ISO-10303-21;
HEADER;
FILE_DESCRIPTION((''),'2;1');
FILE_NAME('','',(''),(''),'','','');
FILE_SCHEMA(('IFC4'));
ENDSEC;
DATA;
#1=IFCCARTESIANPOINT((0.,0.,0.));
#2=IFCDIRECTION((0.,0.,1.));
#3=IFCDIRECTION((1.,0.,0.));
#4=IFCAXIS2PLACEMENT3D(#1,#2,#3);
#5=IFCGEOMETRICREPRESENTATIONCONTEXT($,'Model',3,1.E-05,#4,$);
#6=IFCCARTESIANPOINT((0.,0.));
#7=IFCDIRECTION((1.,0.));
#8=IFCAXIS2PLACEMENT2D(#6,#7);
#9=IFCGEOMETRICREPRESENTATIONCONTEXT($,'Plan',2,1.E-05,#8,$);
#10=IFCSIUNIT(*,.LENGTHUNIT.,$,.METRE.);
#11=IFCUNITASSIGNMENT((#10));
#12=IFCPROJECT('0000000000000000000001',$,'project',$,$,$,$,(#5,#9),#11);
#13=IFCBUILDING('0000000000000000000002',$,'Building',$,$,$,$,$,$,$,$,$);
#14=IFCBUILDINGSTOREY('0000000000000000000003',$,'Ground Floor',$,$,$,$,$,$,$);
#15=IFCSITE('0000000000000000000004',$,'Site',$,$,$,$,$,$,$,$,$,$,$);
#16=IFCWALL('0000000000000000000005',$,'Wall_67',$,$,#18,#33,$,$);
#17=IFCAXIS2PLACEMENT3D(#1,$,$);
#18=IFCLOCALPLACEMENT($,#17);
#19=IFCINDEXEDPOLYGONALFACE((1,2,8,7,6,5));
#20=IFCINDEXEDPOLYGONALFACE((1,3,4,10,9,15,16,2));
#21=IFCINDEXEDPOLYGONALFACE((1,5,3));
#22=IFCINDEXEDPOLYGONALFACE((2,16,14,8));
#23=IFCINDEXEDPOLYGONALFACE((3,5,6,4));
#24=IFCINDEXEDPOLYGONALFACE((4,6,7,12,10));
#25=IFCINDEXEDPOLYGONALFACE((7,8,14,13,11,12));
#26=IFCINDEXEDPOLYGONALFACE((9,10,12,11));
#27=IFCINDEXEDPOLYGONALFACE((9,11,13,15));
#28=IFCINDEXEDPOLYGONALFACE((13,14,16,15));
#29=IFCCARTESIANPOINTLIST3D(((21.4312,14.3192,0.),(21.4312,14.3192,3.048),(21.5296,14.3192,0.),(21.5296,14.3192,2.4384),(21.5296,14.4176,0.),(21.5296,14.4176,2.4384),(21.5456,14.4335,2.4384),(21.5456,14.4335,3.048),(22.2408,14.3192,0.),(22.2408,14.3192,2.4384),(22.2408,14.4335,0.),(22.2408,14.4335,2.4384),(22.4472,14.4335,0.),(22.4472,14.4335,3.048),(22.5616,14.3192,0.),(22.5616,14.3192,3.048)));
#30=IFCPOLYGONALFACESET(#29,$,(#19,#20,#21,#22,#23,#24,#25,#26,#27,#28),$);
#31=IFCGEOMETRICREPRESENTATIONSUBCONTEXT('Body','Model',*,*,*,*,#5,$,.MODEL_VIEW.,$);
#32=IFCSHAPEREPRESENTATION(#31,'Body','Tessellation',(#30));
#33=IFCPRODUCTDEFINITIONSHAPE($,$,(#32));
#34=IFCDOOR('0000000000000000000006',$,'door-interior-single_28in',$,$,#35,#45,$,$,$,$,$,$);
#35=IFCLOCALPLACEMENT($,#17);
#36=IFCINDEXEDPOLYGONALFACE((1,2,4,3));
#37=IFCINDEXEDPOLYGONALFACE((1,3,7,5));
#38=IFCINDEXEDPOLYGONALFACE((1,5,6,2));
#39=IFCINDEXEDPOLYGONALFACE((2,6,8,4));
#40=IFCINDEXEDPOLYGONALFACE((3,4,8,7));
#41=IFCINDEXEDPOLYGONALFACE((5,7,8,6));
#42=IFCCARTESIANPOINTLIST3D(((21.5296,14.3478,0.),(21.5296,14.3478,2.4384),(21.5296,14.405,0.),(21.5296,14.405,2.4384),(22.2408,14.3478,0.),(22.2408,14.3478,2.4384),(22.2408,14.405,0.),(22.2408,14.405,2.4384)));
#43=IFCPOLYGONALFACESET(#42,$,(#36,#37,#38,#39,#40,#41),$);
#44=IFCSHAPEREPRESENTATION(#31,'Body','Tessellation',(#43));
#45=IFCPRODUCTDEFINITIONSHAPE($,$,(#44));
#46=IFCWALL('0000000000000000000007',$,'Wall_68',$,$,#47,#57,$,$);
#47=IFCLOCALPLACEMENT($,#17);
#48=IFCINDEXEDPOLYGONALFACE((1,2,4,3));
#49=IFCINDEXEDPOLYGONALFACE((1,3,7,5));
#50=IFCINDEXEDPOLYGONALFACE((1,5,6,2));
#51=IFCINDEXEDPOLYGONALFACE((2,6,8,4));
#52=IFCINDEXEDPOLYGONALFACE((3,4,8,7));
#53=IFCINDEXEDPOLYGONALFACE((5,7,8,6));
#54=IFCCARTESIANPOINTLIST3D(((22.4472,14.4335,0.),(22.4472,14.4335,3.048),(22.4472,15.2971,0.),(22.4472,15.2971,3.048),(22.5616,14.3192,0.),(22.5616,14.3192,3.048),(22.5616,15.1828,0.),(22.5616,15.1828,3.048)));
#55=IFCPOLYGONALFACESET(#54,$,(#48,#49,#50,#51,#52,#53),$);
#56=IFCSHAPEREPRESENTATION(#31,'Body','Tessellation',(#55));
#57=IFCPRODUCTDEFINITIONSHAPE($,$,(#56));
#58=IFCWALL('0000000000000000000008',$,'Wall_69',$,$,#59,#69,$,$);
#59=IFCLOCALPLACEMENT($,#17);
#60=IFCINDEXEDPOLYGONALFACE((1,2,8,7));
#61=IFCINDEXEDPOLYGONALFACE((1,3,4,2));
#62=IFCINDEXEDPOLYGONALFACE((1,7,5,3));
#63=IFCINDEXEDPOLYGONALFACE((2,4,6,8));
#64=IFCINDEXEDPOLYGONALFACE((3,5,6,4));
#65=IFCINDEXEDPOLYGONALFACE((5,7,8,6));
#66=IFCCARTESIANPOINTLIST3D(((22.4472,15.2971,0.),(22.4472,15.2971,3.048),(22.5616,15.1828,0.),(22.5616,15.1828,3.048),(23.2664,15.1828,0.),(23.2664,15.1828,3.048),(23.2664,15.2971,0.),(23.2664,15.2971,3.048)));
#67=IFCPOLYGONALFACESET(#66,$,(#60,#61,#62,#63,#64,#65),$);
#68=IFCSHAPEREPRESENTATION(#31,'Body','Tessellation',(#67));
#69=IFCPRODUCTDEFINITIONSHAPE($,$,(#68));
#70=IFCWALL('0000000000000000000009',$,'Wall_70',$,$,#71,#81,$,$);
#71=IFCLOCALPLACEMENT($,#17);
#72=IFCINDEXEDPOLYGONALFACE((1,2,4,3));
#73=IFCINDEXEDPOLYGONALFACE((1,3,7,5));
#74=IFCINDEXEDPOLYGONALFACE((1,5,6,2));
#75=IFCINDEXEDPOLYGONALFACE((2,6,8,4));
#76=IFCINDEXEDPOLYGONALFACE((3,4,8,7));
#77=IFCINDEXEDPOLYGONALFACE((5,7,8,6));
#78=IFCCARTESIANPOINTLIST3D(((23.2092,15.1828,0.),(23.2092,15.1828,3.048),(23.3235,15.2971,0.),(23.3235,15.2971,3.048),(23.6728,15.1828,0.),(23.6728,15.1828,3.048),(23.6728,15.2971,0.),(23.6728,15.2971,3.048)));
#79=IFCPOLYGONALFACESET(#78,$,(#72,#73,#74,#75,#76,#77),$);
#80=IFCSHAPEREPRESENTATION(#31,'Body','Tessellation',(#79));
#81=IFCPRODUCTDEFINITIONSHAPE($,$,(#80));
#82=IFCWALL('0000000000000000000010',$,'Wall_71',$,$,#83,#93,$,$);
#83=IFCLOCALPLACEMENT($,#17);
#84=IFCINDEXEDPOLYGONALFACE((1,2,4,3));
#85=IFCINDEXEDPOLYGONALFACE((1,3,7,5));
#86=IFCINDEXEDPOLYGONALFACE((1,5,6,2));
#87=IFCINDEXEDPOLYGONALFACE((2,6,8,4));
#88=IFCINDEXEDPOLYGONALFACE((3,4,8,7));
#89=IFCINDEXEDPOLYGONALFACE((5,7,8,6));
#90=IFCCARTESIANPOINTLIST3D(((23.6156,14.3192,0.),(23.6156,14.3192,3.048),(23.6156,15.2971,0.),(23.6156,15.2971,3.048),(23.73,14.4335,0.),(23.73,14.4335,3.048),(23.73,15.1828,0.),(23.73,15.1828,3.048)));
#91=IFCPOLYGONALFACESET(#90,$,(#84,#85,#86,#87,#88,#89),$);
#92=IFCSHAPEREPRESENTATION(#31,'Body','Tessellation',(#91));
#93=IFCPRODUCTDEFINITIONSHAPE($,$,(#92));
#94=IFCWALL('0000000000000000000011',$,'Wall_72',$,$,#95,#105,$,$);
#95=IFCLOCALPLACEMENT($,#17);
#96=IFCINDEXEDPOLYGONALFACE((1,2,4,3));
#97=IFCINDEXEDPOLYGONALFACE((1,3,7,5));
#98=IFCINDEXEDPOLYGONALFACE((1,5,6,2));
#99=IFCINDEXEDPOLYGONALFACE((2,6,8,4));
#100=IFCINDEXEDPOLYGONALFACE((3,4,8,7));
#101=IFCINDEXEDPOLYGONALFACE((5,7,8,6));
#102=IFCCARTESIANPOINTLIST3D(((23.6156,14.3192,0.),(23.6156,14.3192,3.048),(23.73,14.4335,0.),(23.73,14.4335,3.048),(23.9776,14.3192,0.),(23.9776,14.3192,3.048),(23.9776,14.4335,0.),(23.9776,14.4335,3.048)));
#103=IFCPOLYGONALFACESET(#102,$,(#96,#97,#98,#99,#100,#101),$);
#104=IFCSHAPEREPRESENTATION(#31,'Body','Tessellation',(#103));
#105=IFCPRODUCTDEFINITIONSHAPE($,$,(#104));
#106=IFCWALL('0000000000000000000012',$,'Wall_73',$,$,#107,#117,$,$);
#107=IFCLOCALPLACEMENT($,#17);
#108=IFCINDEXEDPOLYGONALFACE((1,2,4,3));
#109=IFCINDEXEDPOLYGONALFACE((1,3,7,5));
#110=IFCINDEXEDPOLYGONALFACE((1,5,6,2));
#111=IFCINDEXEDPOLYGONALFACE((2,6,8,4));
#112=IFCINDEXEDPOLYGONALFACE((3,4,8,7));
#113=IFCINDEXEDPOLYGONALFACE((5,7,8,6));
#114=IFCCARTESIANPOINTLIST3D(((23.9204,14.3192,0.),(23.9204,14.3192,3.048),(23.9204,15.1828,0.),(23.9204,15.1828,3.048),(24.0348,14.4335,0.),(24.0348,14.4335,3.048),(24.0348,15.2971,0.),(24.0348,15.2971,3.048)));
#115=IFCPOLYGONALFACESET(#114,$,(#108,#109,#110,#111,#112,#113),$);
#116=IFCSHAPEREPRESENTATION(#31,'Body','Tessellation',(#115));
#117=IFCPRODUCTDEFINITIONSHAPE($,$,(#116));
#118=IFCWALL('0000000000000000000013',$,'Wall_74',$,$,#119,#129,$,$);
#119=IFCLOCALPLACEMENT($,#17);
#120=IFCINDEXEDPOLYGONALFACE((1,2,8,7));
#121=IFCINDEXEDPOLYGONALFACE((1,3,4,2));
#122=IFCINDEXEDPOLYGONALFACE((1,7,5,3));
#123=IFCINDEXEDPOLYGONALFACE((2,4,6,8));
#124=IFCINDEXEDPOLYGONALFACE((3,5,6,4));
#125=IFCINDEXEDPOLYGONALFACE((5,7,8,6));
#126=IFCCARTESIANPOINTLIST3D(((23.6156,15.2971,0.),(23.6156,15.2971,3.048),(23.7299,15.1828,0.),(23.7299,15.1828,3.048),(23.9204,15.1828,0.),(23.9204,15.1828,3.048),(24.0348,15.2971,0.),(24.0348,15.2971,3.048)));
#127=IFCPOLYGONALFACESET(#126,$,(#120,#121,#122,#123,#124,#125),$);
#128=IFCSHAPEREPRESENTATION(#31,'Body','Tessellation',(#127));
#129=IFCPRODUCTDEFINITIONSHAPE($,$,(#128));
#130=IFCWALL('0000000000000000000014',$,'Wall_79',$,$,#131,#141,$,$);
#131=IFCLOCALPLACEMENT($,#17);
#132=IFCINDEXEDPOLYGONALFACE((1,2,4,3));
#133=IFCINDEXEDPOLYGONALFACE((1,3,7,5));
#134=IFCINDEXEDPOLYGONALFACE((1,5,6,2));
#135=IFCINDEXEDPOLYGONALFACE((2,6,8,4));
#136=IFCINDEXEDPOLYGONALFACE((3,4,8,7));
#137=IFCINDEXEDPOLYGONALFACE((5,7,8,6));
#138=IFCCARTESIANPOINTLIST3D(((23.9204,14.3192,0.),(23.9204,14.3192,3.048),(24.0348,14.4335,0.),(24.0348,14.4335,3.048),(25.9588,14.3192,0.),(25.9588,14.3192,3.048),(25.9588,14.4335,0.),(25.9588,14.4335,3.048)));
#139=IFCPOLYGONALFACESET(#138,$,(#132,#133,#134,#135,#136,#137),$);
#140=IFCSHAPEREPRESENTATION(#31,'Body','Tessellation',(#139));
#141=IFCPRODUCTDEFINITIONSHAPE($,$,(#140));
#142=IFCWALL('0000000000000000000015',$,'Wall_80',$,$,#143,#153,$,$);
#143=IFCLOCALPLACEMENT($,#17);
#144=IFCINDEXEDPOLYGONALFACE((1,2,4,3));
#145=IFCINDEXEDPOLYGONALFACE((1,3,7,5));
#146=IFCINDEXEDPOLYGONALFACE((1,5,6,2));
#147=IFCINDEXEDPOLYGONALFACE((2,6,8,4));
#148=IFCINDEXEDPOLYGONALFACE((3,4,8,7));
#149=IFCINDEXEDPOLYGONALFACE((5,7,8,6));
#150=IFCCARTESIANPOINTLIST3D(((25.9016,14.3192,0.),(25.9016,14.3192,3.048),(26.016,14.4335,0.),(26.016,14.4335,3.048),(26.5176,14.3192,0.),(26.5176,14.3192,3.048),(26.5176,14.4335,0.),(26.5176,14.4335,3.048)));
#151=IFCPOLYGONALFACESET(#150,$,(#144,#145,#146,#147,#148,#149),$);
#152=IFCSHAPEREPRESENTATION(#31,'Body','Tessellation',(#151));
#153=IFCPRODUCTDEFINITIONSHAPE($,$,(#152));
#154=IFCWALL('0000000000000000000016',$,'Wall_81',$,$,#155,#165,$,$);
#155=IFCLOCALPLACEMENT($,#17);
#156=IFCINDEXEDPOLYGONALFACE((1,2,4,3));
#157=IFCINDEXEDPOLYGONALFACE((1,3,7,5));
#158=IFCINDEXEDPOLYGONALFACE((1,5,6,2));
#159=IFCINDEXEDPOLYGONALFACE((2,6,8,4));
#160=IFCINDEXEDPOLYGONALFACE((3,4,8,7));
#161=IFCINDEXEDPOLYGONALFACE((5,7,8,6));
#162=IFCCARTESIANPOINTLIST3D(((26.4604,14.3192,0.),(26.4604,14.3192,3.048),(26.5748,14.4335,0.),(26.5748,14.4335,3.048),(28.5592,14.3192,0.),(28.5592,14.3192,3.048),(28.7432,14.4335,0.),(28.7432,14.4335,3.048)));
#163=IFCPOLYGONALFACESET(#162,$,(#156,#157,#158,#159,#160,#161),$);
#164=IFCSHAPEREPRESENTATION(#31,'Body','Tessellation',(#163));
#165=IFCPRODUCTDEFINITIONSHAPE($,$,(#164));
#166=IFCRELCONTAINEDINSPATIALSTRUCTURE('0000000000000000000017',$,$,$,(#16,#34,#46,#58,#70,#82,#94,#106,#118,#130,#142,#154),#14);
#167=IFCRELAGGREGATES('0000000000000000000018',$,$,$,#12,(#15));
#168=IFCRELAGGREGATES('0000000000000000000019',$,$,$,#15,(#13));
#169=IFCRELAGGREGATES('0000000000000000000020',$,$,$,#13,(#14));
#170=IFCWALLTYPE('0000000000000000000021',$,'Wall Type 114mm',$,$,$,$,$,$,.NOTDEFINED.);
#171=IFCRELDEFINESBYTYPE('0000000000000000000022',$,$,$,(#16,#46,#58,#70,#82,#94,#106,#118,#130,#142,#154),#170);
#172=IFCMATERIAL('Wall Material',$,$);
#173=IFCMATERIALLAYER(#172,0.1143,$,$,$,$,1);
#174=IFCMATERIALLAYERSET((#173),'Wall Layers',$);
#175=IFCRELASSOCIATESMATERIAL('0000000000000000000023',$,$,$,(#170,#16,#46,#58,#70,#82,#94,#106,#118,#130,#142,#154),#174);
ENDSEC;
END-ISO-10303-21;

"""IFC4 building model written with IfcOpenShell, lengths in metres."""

from ifc_helpers import new_model, si_unit, frame, origin_with_axes, origin_2d_with_axis, place, context, subcontext, project, spatial, line, indexed_curve, rectangle, outline, extrude, material, layer, layer_set, layer_usage, type_object, element, fill, save


model = new_model("IFC4")

# Units and contexts
model_context = context("Model", 3, precision=1e-05, world=origin_with_axes())
plan_context = context("Plan", 2, precision=1e-05, world=origin_2d_with_axis())
body_context = subcontext(model_context, "Body", "Model", "MODEL_VIEW")
ifc_project = project(units=[si_unit("LENGTHUNIT", "METRE")], contexts=[model_context, plan_context])

# Site, building, storey
site = spatial("IfcSite", under=ifc_project, Name="Site")
building = spatial("IfcBuilding", under=site, Name="Building")
storey = spatial("IfcBuildingStorey", under=building, Name="Ground Floor")

# Shared definitions
ifc_material_1 = material(Name="Wall Material")
ifc_layer_1 = layer(ifc_material_1, 0.1143, Priority=1)
ifc_layer_set_1 = layer_set([ifc_layer_1], Name="Wall Layers")
wall_type_1 = type_object("IfcWallType", Name="Wall Type 114mm", PredefinedType="NOTDEFINED", material=ifc_layer_set_1)

# Wall, opening, door
ifc_layer_usage_1 = layer_usage(ifc_layer_set_1, "AXIS2", "POSITIVE", -0.0571)
wall_1_placement = place(None, frame((21.4884, 14.3764, 0.0), z_axis=(0.0, 0.0, 1.0), x_axis=(1.0, 0.0, 0.0)))
wall_1 = element("IfcWall", 1, at=wall_1_placement, inside=storey, type_object=wall_type_1, material=ifc_layer_usage_1, Name="Wall_67", context=body_context, shape_type="SweptSolid", body=[
    extrude(outline(indexed_curve([(-0.0571, -0.0571), (0.0571, 0.0571), (0.9589, 0.0571), (1.0732, -0.0571)], segments=[line(1, 2, 3, 4, 1)])), origin_with_axes(), (0.0, 0.0, 1.0), 3.048),
])
opening_1_placement = place(wall_1_placement, frame((0.3968, 0.0, 0.0), z_axis=(0.0, 0.0, 1.0), x_axis=(1.0, 0.0, 0.0)))
opening_1 = element("IfcOpeningElement", 2, at=opening_1_placement, cuts=wall_1, context=body_context, shape_type="SweptSolid", body=[
    extrude(rectangle(XDim=0.7112, YDim=0.5), None, (0.0, 0.0, 1.0), 2.4384),
])
door_1_placement = place(None, frame((21.8852, 14.3764, 0.0), z_axis=(0.0, 0.0, 1.0), x_axis=(-1.0, 0.0, 0.0)))
door_1 = element("IfcDoor", 3, at=door_1_placement, inside=storey, Name="door-interior-single_28in", context=body_context, shape_type="SweptSolid", body=[
    extrude(rectangle(XDim=0.7112, YDim=0.0571), None, (0.0, 0.0, 1.0), 2.4384),
])
fill(opening_1, door_1)

# Walls
ifc_layer_usage_2 = layer_usage(ifc_layer_set_1, "AXIS2", "POSITIVE", -0.0571)
wall_2_placement = place(None, frame((22.5044, 14.3764, 0.0), z_axis=(0.0, 0.0, 1.0), x_axis=(0.0, 1.0, 0.0)))
element("IfcWall", 4, at=wall_2_placement, inside=storey, type_object=wall_type_1, material=ifc_layer_usage_2, Name="Wall_68", context=body_context, shape_type="SweptSolid", body=[
    extrude(outline(indexed_curve([(-0.0571, -0.0571), (0.0571, 0.0571), (0.9207, 0.0571), (0.8064, -0.0571)], segments=[line(1, 2, 3, 4, 1)])), origin_with_axes(), (0.0, 0.0, 1.0), 3.048),
])
ifc_layer_usage_3 = layer_usage(ifc_layer_set_1, "AXIS2", "POSITIVE", -0.0571)
wall_3_placement = place(None, frame((22.5044, 15.24, 0.0), z_axis=(0.0, 0.0, 1.0), x_axis=(1.0, 0.0, 0.0)))
element("IfcWall", 5, at=wall_3_placement, inside=storey, type_object=wall_type_1, material=ifc_layer_usage_3, Name="Wall_69", context=body_context, shape_type="SweptSolid", body=[
    extrude(outline(indexed_curve([(0.0571, -0.0571), (-0.0571, 0.0571), (0.762, 0.0571), (0.762, -0.0571)], segments=[line(1, 2, 3, 4, 1)])), origin_with_axes(), (0.0, 0.0, 1.0), 3.048),
])
ifc_layer_usage_4 = layer_usage(ifc_layer_set_1, "AXIS2", "POSITIVE", -0.0571)
wall_4_placement = place(None, frame((23.2664, 15.24, 0.0), z_axis=(0.0, 0.0, 1.0), x_axis=(1.0, 0.0, 0.0)))
element("IfcWall", 6, at=wall_4_placement, inside=storey, type_object=wall_type_1, material=ifc_layer_usage_4, Name="Wall_70", context=body_context, shape_type="SweptSolid", body=[
    extrude(outline(indexed_curve([(-0.0571, -0.0571), (0.0571, 0.0571), (0.4064, 0.0571), (0.4064, -0.0571)], segments=[line(1, 2, 3, 4, 1)])), origin_with_axes(), (0.0, 0.0, 1.0), 3.048),
])
ifc_layer_usage_5 = layer_usage(ifc_layer_set_1, "AXIS2", "POSITIVE", -0.0571)
wall_5_placement = place(None, frame((23.6728, 15.24, 0.0), z_axis=(0.0, 0.0, 1.0), x_axis=(0.0, -1.0, 0.0)))
element("IfcWall", 7, at=wall_5_placement, inside=storey, type_object=wall_type_1, material=ifc_layer_usage_5, Name="Wall_71", context=body_context, shape_type="SweptSolid", body=[
    extrude(outline(indexed_curve([(-0.0572, -0.0571), (0.0572, 0.0571), (0.8064, 0.0571), (0.9207, -0.0571)], segments=[line(1, 2, 3, 4, 1)])), origin_with_axes(), (0.0, 0.0, 1.0), 3.048),
])
ifc_layer_usage_6 = layer_usage(ifc_layer_set_1, "AXIS2", "POSITIVE", -0.0571)
wall_6_placement = place(None, frame((23.6728, 14.3764, 0.0), z_axis=(0.0, 0.0, 1.0), x_axis=(1.0, 0.0, 0.0)))
element("IfcWall", 8, at=wall_6_placement, inside=storey, type_object=wall_type_1, material=ifc_layer_usage_6, Name="Wall_72", context=body_context, shape_type="SweptSolid", body=[
    extrude(outline(indexed_curve([(-0.0571, -0.0571), (0.0571, 0.0571), (0.3048, 0.0571), (0.3048, -0.0571)], segments=[line(1, 2, 3, 4, 1)])), origin_with_axes(), (0.0, 0.0, 1.0), 3.048),
])
ifc_layer_usage_7 = layer_usage(ifc_layer_set_1, "AXIS2", "POSITIVE", -0.0571)
wall_7_placement = place(None, frame((23.9776, 14.3764, 0.0), z_axis=(0.0, 0.0, 1.0), x_axis=(0.0, 1.0, 0.0)))
element("IfcWall", 9, at=wall_7_placement, inside=storey, type_object=wall_type_1, material=ifc_layer_usage_7, Name="Wall_73", context=body_context, shape_type="SweptSolid", body=[
    extrude(outline(indexed_curve([(0.0571, -0.0571), (-0.0571, 0.0571), (0.8064, 0.0571), (0.9207, -0.0571)], segments=[line(1, 2, 3, 4, 1)])), origin_with_axes(), (0.0, 0.0, 1.0), 3.048),
])
ifc_layer_usage_8 = layer_usage(ifc_layer_set_1, "AXIS2", "POSITIVE", -0.0571)
wall_8_placement = place(None, frame((23.9776, 15.24, 0.0), z_axis=(0.0, 0.0, 1.0), x_axis=(-1.0, 0.0, 0.0)))
element("IfcWall", 10, at=wall_8_placement, inside=storey, type_object=wall_type_1, material=ifc_layer_usage_8, Name="Wall_74", context=body_context, shape_type="SweptSolid", body=[
    extrude(outline(indexed_curve([(-0.0571, -0.0571), (0.0571, 0.0571), (0.2477, 0.0571), (0.362, -0.0571)], segments=[line(1, 2, 3, 4, 1)])), origin_with_axes(), (0.0, 0.0, 1.0), 3.048),
])
ifc_layer_usage_9 = layer_usage(ifc_layer_set_1, "AXIS2", "POSITIVE", -0.0571)
wall_9_placement = place(None, frame((23.9776, 14.3764, 0.0), z_axis=(0.0, 0.0, 1.0), x_axis=(1.0, 0.0, 0.0)))
element("IfcWall", 11, at=wall_9_placement, inside=storey, type_object=wall_type_1, material=ifc_layer_usage_9, Name="Wall_79", context=body_context, shape_type="SweptSolid", body=[
    extrude(outline(indexed_curve([(-0.0572, -0.0571), (0.0572, 0.0571), (1.9812, 0.0571), (1.9812, -0.0571)], segments=[line(1, 2, 3, 4, 1)])), origin_with_axes(), (0.0, 0.0, 1.0), 3.048),
])
ifc_layer_usage_10 = layer_usage(ifc_layer_set_1, "AXIS2", "POSITIVE", -0.0571)
wall_10_placement = place(None, frame((25.9588, 14.3764, 0.0), z_axis=(0.0, 0.0, 1.0), x_axis=(1.0, 0.0, 0.0)))
element("IfcWall", 12, at=wall_10_placement, inside=storey, type_object=wall_type_1, material=ifc_layer_usage_10, Name="Wall_80", context=body_context, shape_type="SweptSolid", body=[
    extrude(outline(indexed_curve([(-0.0571, -0.0571), (0.0571, 0.0571), (0.5588, 0.0571), (0.5588, -0.0571)], segments=[line(1, 2, 3, 4, 1)])), origin_with_axes(), (0.0, 0.0, 1.0), 3.048),
])
ifc_layer_usage_11 = layer_usage(ifc_layer_set_1, "AXIS2", "POSITIVE", -0.0571)
wall_11_placement = place(None, frame((26.5176, 14.3764, 0.0), z_axis=(0.0, 0.0, 1.0), x_axis=(1.0, 0.0, 0.0)))
element("IfcWall", 13, at=wall_11_placement, inside=storey, type_object=wall_type_1, material=ifc_layer_usage_11, Name="Wall_81", context=body_context, shape_type="SweptSolid", body=[
    extrude(outline(indexed_curve([(-0.0571, -0.0571), (0.0571, 0.0571), (2.2257, 0.0571), (2.0416, -0.0571)], segments=[line(1, 2, 3, 4, 1)])), origin_with_axes(), (0.0, 0.0, 1.0), 3.048),
])

save(model, "model.ifc")
